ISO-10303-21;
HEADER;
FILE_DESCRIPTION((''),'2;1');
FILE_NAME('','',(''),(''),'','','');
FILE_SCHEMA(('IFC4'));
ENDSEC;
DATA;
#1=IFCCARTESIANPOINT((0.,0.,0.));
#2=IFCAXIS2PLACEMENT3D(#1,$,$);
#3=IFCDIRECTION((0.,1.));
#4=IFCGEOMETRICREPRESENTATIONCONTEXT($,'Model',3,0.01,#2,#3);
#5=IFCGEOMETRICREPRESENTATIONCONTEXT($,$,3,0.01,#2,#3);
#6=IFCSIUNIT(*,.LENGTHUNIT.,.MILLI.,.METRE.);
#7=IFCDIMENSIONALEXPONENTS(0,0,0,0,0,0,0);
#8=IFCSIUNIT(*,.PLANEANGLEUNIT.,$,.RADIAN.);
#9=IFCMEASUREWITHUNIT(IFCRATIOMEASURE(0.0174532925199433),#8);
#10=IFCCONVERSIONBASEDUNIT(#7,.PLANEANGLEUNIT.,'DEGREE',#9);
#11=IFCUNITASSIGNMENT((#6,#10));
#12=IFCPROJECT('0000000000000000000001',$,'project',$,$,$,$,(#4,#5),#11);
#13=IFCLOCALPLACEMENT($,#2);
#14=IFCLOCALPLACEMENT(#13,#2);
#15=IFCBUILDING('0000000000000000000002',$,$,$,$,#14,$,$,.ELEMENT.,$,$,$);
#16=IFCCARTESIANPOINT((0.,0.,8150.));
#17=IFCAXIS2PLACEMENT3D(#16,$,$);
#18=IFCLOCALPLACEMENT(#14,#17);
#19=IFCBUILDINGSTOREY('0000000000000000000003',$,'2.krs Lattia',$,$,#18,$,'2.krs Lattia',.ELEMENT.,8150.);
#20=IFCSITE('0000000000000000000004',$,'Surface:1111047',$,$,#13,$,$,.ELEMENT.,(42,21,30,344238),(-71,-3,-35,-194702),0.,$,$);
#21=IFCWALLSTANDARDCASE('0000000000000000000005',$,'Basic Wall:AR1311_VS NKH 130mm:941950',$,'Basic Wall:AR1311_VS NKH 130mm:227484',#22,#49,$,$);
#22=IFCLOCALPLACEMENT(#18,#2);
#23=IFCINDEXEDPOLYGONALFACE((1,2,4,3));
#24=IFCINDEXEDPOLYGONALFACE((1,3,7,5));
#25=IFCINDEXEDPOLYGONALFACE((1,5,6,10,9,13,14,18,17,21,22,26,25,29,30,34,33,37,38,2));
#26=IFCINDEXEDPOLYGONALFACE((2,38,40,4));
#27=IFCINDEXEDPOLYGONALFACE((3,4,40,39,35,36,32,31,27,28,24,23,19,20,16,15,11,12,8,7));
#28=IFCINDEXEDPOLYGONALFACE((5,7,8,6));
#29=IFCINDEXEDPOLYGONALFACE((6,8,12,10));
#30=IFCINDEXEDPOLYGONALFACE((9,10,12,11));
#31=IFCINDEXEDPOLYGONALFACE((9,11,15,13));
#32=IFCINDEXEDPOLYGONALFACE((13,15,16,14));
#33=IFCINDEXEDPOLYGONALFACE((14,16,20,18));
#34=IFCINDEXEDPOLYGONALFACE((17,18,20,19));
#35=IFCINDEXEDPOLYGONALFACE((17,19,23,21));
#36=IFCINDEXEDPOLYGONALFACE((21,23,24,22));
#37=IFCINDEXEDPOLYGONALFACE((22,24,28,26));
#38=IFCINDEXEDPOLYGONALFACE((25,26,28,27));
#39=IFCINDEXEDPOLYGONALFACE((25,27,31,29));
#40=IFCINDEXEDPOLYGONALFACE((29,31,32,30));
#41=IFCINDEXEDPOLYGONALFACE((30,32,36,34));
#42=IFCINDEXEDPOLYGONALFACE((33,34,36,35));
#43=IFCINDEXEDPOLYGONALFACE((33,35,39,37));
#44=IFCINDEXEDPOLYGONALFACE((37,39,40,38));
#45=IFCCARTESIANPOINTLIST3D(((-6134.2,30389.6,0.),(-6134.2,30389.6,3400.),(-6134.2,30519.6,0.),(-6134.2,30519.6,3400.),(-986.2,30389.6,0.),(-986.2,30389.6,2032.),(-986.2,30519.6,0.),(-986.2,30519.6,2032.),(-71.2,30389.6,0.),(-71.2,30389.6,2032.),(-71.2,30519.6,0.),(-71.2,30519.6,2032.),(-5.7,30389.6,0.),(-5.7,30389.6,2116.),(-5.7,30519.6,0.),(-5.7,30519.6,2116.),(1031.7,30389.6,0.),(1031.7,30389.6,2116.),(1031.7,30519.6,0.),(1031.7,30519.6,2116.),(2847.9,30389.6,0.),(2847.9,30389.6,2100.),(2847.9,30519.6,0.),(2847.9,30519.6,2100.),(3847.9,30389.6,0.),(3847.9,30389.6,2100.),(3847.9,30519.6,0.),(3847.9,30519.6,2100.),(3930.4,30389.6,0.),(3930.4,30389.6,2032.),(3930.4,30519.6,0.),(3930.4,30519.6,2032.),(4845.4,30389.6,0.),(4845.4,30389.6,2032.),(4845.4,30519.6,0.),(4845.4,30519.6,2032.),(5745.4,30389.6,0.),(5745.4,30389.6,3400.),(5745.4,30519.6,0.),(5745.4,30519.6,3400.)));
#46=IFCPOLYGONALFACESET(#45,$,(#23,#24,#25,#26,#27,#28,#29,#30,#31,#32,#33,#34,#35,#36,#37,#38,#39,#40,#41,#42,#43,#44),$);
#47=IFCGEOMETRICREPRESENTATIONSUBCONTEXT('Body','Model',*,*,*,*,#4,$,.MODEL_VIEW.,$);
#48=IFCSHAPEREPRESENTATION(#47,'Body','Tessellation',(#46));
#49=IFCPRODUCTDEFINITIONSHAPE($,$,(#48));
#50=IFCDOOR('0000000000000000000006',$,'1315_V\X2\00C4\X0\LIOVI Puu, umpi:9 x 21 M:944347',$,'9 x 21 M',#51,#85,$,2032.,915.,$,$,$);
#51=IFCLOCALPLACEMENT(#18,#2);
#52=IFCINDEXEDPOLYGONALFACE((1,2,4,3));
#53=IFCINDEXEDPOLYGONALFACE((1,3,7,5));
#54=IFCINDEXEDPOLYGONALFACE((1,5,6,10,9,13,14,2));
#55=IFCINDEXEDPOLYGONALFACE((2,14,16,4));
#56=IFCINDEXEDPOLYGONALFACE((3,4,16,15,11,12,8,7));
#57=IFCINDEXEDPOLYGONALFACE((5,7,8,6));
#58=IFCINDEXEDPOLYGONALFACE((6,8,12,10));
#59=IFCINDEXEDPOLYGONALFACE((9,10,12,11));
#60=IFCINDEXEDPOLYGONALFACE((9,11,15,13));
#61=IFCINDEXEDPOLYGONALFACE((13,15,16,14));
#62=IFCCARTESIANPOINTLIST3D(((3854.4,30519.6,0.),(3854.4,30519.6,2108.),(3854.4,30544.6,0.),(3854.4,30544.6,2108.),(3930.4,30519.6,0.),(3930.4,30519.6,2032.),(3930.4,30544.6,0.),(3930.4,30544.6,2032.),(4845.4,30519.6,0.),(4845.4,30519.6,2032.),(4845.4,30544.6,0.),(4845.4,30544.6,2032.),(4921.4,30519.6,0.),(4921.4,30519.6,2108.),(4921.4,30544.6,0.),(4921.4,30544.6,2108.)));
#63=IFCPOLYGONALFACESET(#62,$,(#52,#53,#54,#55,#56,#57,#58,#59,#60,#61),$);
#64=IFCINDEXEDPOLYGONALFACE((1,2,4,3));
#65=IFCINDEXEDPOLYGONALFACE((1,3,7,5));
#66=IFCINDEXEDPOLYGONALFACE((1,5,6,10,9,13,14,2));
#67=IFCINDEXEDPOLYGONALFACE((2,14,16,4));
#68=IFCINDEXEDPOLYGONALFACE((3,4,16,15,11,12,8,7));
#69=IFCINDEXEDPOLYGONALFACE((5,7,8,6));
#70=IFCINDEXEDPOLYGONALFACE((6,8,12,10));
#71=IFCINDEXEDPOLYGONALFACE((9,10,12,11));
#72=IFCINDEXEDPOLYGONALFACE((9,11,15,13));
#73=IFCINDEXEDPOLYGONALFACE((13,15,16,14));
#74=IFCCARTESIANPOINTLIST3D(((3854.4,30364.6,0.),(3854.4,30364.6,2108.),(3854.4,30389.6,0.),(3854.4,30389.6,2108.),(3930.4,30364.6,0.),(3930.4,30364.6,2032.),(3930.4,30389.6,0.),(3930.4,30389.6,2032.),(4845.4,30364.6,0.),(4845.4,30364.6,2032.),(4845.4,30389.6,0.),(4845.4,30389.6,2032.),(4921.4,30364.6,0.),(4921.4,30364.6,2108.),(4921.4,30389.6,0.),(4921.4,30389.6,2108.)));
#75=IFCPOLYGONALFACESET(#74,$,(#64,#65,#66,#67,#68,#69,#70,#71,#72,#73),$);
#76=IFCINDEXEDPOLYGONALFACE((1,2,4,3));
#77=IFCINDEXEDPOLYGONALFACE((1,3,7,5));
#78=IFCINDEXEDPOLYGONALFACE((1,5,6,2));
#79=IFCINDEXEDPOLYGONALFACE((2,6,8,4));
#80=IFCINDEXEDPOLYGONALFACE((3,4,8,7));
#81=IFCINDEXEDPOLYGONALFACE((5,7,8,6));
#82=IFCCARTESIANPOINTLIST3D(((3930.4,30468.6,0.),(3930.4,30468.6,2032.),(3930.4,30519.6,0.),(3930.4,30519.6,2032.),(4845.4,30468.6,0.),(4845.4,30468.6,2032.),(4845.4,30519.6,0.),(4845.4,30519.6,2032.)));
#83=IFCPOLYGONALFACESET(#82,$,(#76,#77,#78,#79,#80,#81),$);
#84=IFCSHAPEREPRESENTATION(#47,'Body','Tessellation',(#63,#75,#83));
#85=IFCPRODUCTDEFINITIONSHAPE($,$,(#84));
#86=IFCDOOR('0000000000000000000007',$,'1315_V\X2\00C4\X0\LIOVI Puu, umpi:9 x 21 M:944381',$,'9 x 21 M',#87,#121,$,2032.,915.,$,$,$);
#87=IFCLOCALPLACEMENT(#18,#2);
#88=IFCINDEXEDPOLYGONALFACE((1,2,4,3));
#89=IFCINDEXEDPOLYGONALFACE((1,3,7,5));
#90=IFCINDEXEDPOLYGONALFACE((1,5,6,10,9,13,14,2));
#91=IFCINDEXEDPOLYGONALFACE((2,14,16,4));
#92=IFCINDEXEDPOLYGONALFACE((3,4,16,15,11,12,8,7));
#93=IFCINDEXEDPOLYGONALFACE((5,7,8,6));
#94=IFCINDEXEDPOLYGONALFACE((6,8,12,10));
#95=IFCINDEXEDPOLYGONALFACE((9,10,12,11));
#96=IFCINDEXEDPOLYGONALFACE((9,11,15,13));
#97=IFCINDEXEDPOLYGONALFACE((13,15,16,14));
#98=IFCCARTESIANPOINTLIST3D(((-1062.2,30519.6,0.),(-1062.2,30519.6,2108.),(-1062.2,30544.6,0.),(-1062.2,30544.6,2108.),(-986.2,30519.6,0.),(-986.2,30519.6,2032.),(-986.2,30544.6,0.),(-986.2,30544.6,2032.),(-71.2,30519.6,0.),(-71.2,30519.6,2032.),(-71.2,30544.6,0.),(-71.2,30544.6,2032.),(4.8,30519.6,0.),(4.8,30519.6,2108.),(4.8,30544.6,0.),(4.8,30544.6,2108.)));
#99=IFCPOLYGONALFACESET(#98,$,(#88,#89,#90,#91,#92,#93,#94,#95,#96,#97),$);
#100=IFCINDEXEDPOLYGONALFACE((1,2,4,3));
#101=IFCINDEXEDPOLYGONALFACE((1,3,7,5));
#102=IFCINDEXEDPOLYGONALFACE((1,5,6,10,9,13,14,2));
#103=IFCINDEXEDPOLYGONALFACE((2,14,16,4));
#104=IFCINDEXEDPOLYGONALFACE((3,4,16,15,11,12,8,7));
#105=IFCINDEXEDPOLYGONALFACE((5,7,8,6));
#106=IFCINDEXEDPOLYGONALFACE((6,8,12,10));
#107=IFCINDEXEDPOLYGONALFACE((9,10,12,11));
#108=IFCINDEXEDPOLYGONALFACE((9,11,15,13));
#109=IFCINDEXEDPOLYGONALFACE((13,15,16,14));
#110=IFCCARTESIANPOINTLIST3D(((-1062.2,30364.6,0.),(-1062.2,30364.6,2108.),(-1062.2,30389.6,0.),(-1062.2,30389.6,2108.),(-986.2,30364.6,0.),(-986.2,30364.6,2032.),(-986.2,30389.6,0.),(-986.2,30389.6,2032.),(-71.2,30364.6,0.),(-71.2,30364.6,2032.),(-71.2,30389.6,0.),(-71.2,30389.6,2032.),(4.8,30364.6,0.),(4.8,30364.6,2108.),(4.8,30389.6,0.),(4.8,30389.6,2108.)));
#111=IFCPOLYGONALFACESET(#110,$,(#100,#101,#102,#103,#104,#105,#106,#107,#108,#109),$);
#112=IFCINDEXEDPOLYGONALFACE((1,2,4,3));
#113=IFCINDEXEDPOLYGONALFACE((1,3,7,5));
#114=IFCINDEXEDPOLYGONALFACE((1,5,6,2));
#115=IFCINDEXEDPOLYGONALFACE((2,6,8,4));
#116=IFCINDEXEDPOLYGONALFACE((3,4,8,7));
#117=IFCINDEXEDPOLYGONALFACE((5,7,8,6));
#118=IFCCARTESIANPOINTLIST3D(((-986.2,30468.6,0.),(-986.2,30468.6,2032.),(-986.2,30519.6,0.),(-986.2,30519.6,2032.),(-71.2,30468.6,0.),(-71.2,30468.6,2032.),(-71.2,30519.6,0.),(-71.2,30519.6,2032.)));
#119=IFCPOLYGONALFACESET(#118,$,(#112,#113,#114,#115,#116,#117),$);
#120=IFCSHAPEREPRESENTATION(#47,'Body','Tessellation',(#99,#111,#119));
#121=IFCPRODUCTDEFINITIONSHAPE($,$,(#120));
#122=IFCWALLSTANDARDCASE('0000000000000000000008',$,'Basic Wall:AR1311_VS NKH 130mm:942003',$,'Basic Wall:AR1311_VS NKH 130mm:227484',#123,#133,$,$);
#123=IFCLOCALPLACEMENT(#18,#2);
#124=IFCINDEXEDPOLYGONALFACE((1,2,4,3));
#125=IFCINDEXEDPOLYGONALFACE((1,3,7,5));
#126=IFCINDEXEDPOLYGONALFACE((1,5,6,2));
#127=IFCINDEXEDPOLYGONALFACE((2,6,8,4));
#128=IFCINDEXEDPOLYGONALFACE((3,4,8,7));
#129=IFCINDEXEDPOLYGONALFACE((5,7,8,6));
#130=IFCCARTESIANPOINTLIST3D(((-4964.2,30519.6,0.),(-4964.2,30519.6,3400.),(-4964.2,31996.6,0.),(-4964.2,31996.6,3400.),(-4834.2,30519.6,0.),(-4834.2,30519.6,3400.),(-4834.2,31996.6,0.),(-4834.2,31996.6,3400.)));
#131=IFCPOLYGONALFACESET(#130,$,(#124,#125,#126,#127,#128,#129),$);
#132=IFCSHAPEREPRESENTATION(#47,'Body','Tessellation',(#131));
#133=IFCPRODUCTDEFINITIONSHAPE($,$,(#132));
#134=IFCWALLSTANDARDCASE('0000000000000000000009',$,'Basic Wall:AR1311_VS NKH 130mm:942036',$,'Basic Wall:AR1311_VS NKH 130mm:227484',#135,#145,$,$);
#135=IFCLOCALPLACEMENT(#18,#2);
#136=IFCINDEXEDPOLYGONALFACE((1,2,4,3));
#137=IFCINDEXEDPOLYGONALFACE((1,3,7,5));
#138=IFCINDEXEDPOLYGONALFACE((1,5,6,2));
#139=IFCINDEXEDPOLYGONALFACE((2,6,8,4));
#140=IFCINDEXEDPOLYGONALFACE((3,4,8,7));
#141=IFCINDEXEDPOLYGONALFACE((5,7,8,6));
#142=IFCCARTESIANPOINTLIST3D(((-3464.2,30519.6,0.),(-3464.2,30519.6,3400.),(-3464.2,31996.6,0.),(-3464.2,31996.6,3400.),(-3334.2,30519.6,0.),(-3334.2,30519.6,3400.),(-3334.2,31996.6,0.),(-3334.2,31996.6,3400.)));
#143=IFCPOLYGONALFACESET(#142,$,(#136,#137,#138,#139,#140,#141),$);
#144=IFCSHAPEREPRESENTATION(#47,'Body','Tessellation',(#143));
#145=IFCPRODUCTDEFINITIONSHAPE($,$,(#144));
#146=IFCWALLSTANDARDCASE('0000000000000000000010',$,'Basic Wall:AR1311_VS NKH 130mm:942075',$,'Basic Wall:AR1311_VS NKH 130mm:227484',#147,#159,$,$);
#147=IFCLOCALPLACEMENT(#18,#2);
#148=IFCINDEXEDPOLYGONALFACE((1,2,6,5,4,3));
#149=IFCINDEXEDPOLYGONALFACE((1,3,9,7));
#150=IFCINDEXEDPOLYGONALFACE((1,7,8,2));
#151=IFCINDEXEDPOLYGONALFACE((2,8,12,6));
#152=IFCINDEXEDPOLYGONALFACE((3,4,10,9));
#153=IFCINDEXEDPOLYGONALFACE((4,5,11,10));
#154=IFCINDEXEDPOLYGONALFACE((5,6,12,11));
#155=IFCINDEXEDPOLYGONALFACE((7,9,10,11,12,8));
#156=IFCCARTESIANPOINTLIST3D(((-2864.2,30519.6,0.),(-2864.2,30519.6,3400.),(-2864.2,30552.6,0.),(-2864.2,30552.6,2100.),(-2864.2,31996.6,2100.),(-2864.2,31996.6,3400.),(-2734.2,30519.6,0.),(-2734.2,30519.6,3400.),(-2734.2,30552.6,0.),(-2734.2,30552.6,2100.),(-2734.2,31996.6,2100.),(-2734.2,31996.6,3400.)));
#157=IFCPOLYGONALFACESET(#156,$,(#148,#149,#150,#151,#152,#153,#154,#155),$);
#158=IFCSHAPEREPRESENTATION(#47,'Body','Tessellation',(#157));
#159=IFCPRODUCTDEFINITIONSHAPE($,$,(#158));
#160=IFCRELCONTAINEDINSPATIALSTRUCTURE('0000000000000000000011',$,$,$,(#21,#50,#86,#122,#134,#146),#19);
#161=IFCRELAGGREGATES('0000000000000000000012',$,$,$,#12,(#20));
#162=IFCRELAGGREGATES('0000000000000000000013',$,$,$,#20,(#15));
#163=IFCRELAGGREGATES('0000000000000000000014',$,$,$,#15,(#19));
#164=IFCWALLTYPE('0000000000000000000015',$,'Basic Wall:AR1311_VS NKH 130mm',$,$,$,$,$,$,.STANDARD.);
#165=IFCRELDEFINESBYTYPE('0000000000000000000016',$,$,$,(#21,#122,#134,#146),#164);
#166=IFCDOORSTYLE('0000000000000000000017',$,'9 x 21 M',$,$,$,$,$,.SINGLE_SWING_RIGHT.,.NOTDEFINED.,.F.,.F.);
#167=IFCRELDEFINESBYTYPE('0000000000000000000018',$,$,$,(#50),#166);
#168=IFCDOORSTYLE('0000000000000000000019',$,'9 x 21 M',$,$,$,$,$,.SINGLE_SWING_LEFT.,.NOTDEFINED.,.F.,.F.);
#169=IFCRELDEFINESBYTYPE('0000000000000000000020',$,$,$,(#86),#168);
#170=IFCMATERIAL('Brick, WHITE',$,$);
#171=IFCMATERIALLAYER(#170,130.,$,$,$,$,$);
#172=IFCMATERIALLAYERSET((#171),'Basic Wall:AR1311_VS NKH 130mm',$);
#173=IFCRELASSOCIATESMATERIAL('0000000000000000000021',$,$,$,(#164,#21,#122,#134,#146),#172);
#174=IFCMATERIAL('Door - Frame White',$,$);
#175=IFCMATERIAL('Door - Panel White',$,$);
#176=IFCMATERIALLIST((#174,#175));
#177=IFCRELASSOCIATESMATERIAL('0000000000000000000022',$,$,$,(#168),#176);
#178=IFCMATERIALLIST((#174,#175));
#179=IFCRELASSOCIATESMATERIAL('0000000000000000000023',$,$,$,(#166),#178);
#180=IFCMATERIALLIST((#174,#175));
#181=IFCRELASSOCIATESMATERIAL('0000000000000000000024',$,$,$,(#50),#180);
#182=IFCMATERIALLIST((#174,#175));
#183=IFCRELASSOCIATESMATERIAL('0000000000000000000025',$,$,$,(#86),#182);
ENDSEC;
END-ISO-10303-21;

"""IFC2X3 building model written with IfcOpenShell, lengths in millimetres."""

from ifc_helpers import new_model, entity, si_unit, converted_unit, direction, frame, frame_2d, origin, place, context, subcontext, project, spatial, polyline, rectangle, outline, extrude, source, transform, mapped, material, material_list, layer, layer_set, layer_usage, type_object, type_shapes, element, fill, save


model = new_model("IFC2X3")

# Units and contexts
model_context = context("Model", 3, precision=0.01, world=origin(), true_north=direction((0.0, 1.0)))
context_of_model = context(None, 3, precision=0.01, world=origin(), true_north=direction((0.0, 1.0)))
body_context = subcontext(model_context, "Body", "Model", "MODEL_VIEW")
ifc_project = project(units=[si_unit("LENGTHUNIT", "METRE", prefix="MILLI"), converted_unit("PLANEANGLEUNIT", "DEGREE", entity("IfcRatioMeasure", 0.0174532925199433), si_unit("PLANEANGLEUNIT", "RADIAN"), dimensions=[0, 0, 0, 0, 0, 0, 0])], contexts=[model_context, context_of_model])

# Site, building, storey
site_placement = place(None, origin())
site = spatial("IfcSite", under=ifc_project, at=site_placement, Name="Surface:1111047", CompositionType="ELEMENT", RefLatitude=(42, 21, 30, 344238), RefLongitude=(-71, -3, -35, -194702), RefElevation=0.0)
building_placement = place(site_placement, origin())
building = spatial("IfcBuilding", under=site, at=building_placement, CompositionType="ELEMENT")
storey_placement = place(building_placement, frame((0.0, 0.0, 8150.0)))
storey = spatial("IfcBuildingStorey", under=building, at=storey_placement, Name="2.krs Lattia", LongName="2.krs Lattia", CompositionType="ELEMENT", Elevation=8150.0)

# Shared definitions
ifc_material_1 = material(Name="Brick, WHITE")
ifc_layer = layer(ifc_material_1, 130.0)
ifc_layer_set = layer_set([ifc_layer], Name="Basic Wall:AR1311_VS NKH 130mm")
wall_type = type_object("IfcWallType", Name="Basic Wall:AR1311_VS NKH 130mm", PredefinedType="STANDARD", material=ifc_layer_set)

# Wall, openings, doors
ifc_material_2 = material(Name="Door - Frame White")
ifc_material_3 = material(Name="Door - Panel White")
ifc_material_list_1 = material_list([ifc_material_2, ifc_material_3])
door_style_1 = type_object("IfcDoorStyle", Name="9 x 21 M", ConstructionType="NOTDEFINED", OperationType="SINGLE_SWING_LEFT", ParameterTakesPrecedence=False, Sizeable=False, material=ifc_material_list_1)
shared_shape_1 = source(origin(), body_context, "Body", "SweptSolid", [
    extrude(outline(polyline([(-533.5, -1073.0), (533.5, -1073.0), (533.5, 1035.0), (457.5, 1035.0), (457.5, -997.0), (-457.5, -997.0), (-457.5, 1035.0), (-533.5, 1035.0), (-533.5, -1073.0)])), frame((457.5, 155.0, 1035.0), z_axis=(0.0, -1.0, 0.0), x_axis=(-1.0, 0.0, 0.0)), (0.0, 0.0, 1.0), 25.0),
    extrude(outline(polyline([(-1073.0, -533.5), (1035.0, -533.5), (1035.0, -457.5), (-997.0, -457.5), (-997.0, 457.5), (1035.0, 457.5), (1035.0, 533.5), (-1073.0, 533.5), (-1073.0, -533.5)])), frame((457.5, 0.0, 1035.0), z_axis=(0.0, -1.0, 0.0), x_axis=(0.0, 0.0, -1.0)), (0.0, 0.0, 1.0), 25.0),
    extrude(rectangle(XDim=915.0, YDim=51.0, at=frame_2d((0.0, 0.0), x_axis=(1.0, 0.0))), frame((457.5, 104.5, 0.0)), (0.0, 0.0, 1.0), 2032.0),
])
type_shapes(door_style_1, [shared_shape_1])
ifc_layer_usage_1 = layer_usage(ifc_layer_set, "AXIS2", "NEGATIVE", 65.0)
wall_1_placement = place(storey_placement, frame((-6134.2, 30454.6, 0.0)))
wall_1 = element("IfcWallStandardCase", 1, at=wall_1_placement, inside=storey, type_object=wall_type, material=ifc_layer_usage_1, Name="Basic Wall:AR1311_VS NKH 130mm:941950", ObjectType="Basic Wall:AR1311_VS NKH 130mm:227484", context=body_context, shape_type="SweptSolid", body=[
    extrude(rectangle(XDim=11879.5, YDim=130.0, at=frame_2d((5939.8, 0.0), x_axis=(-1.0, 0.0))), origin(), (0.0, 0.0, 1.0), 3400.0),
])
opening_1_placement = place(wall_1_placement, origin())
element("IfcOpeningElement", 2, at=opening_1_placement, cuts=wall_1, ObjectType="Opening", context=body_context, shape_type="SweptSolid", body=[
    extrude(rectangle(XDim=2116.0, YDim=1037.4, at=frame_2d((0.0, 0.0), x_axis=(1.0, 0.0))), frame((6647.2, -65.0, 1058.0), z_axis=(0.0, 1.0, 0.0), x_axis=(0.0, 0.0, -1.0)), (0.0, 0.0, 1.0), 130.0),
])
opening_2_placement = place(wall_1_placement, origin())
element("IfcOpeningElement", 3, at=opening_2_placement, cuts=wall_1, ObjectType="Opening", context=body_context, shape_type="SweptSolid", body=[
    extrude(rectangle(XDim=2100.0, YDim=1000.0, at=frame_2d((0.0, 0.0), x_axis=(1.0, 0.0))), frame((9482.0, -65.0, 1050.0), z_axis=(0.0, 1.0, 0.0), x_axis=(0.0, 0.0, -1.0)), (0.0, 0.0, 1.0), 130.0),
])
opening_3_placement = place(wall_1_placement, frame((10064.5, -65.0, 0.0)))
opening_3 = element("IfcOpeningElement", 4, at=opening_3_placement, cuts=wall_1, ObjectType="Opening", context=body_context, shape_type="SweptSolid", body=[
    extrude(rectangle(XDim=915.0, YDim=2032.0, at=frame_2d((1016.0, 457.5), x_axis=(0.0, 1.0))), frame((0.0, 0.0, 0.0), z_axis=(0.0, 1.0, 0.0), x_axis=(0.0, 0.0, 1.0)), (0.0, 0.0, 1.0), 130.0),
])
opening_4_placement = place(wall_1_placement, frame((5147.9, -65.0, 0.0)))
opening_4 = element("IfcOpeningElement", 5, at=opening_4_placement, cuts=wall_1, ObjectType="Opening", context=body_context, shape_type="SweptSolid", body=[
    extrude(rectangle(XDim=915.0, YDim=2032.0, at=frame_2d((1016.0, 457.5), x_axis=(0.0, -1.0))), frame((0.0, 0.0, 0.0), z_axis=(0.0, 1.0, 0.0), x_axis=(0.0, 0.0, 1.0)), (0.0, 0.0, 1.0), 130.0),
])
ifc_material_list_2 = material_list([ifc_material_2, ifc_material_3])
ifc_material_list_3 = material_list([ifc_material_2, ifc_material_3])
door_style_2 = type_object("IfcDoorStyle", Name="9 x 21 M", ConstructionType="NOTDEFINED", OperationType="SINGLE_SWING_RIGHT", ParameterTakesPrecedence=False, Sizeable=False, material=ifc_material_list_3)
shared_shape_2 = source(origin(), body_context, "Body", "SweptSolid", [
    extrude(outline(polyline([(-533.5, -1073.0), (533.5, -1073.0), (533.5, 1035.0), (457.5, 1035.0), (457.5, -997.0), (-457.5, -997.0), (-457.5, 1035.0), (-533.5, 1035.0), (-533.5, -1073.0)])), frame((457.5, 130.0, 1035.0), z_axis=(0.0, 1.0, 0.0), x_axis=(1.0, 0.0, 0.0)), (0.0, 0.0, 1.0), 25.0),
    extrude(outline(polyline([(-1073.0, -533.5), (1035.0, -533.5), (1035.0, -457.5), (-997.0, -457.5), (-997.0, 457.5), (1035.0, 457.5), (1035.0, 533.5), (-1073.0, 533.5), (-1073.0, -533.5)])), frame((457.5, -25.0, 1035.0), z_axis=(0.0, 1.0, 0.0), x_axis=(0.0, 0.0, -1.0)), (0.0, 0.0, 1.0), 25.0),
    extrude(rectangle(XDim=51.0, YDim=915.0, at=frame_2d((0.0, 0.0), x_axis=(1.0, 0.0))), frame((457.5, 104.5, 0.0), z_axis=(0.0, 0.0, 1.0), x_axis=(0.0, 1.0, 0.0)), (0.0, 0.0, 1.0), 2032.0),
])
type_shapes(door_style_2, [shared_shape_2])
door_1_placement = place(opening_3_placement, origin())
door_1 = element("IfcDoor", 6, at=door_1_placement, inside=storey, type_object=door_style_2, material=ifc_material_list_2, Name="1315_VÄLIOVI Puu, umpi:9 x 21 M:944347", ObjectType="9 x 21 M", OverallHeight=2032.0, OverallWidth=915.0, context=body_context, shape_type="MappedRepresentation", body=[
    mapped(shared_shape_2, transform((0.0, 0.0, 0.0), scale=1.0)),
])
fill(opening_3, door_1)
ifc_material_list_4 = material_list([ifc_material_2, ifc_material_3])
door_2_placement = place(opening_4_placement, origin())
door_2 = element("IfcDoor", 7, at=door_2_placement, inside=storey, type_object=door_style_1, material=ifc_material_list_4, Name="1315_VÄLIOVI Puu, umpi:9 x 21 M:944381", ObjectType="9 x 21 M", OverallHeight=2032.0, OverallWidth=915.0, context=body_context, shape_type="MappedRepresentation", body=[
    mapped(shared_shape_1, transform((0.0, 0.0, 0.0), scale=1.0)),
])
fill(opening_4, door_2)

# Walls
ifc_layer_usage_2 = layer_usage(ifc_layer_set, "AXIS2", "NEGATIVE", 65.0)
wall_2_placement = place(storey_placement, frame((-4899.2, 31996.6, 0.0), z_axis=(0.0, 0.0, 1.0), x_axis=(0.0, -1.0, 0.0)))
element("IfcWallStandardCase", 8, at=wall_2_placement, inside=storey, type_object=wall_type, material=ifc_layer_usage_2, Name="Basic Wall:AR1311_VS NKH 130mm:942003", ObjectType="Basic Wall:AR1311_VS NKH 130mm:227484", context=body_context, shape_type="SweptSolid", body=[
    extrude(rectangle(XDim=1477.0, YDim=130.0, at=frame_2d((738.5, 0.0), x_axis=(-1.0, 0.0))), origin(), (0.0, 0.0, 1.0), 3400.0),
])
ifc_layer_usage_3 = layer_usage(ifc_layer_set, "AXIS2", "NEGATIVE", 65.0)
wall_3_placement = place(storey_placement, frame((-3399.2, 31996.6, 0.0), z_axis=(0.0, 0.0, 1.0), x_axis=(0.0, -1.0, 0.0)))
element("IfcWallStandardCase", 9, at=wall_3_placement, inside=storey, type_object=wall_type, material=ifc_layer_usage_3, Name="Basic Wall:AR1311_VS NKH 130mm:942036", ObjectType="Basic Wall:AR1311_VS NKH 130mm:227484", context=body_context, shape_type="SweptSolid", body=[
    extrude(rectangle(XDim=1477.0, YDim=130.0, at=frame_2d((738.5, 0.0), x_axis=(-1.0, 0.0))), origin(), (0.0, 0.0, 1.0), 3400.0),
])

# Wall, opening
ifc_layer_usage_4 = layer_usage(ifc_layer_set, "AXIS2", "NEGATIVE", 65.0)
wall_4_placement = place(storey_placement, frame((-2799.2, 31996.6, 0.0), z_axis=(0.0, 0.0, 1.0), x_axis=(0.0, -1.0, 0.0)))
wall_4 = element("IfcWallStandardCase", 10, at=wall_4_placement, inside=storey, type_object=wall_type, material=ifc_layer_usage_4, Name="Basic Wall:AR1311_VS NKH 130mm:942075", ObjectType="Basic Wall:AR1311_VS NKH 130mm:227484", context=body_context, shape_type="SweptSolid", body=[
    extrude(rectangle(XDim=1477.0, YDim=130.0, at=frame_2d((738.5, 0.0), x_axis=(-1.0, 0.0))), origin(), (0.0, 0.0, 1.0), 3400.0),
])
opening_5_placement = place(wall_4_placement, frame((-66.0, -65.0, 0.0)))
element("IfcOpeningElement", 11, at=opening_5_placement, cuts=wall_4, ObjectType="Opening", context=body_context, shape_type="SweptSolid", body=[
    extrude(rectangle(XDim=2100.0, YDim=1510.0, at=frame_2d((1050.0, 755.0), x_axis=(1.0, 0.0))), frame((0.0, 0.0, 0.0), z_axis=(0.0, 1.0, 0.0), x_axis=(0.0, 0.0, 1.0)), (0.0, 0.0, 1.0), 130.0),
])

save(model, "model.ifc")
